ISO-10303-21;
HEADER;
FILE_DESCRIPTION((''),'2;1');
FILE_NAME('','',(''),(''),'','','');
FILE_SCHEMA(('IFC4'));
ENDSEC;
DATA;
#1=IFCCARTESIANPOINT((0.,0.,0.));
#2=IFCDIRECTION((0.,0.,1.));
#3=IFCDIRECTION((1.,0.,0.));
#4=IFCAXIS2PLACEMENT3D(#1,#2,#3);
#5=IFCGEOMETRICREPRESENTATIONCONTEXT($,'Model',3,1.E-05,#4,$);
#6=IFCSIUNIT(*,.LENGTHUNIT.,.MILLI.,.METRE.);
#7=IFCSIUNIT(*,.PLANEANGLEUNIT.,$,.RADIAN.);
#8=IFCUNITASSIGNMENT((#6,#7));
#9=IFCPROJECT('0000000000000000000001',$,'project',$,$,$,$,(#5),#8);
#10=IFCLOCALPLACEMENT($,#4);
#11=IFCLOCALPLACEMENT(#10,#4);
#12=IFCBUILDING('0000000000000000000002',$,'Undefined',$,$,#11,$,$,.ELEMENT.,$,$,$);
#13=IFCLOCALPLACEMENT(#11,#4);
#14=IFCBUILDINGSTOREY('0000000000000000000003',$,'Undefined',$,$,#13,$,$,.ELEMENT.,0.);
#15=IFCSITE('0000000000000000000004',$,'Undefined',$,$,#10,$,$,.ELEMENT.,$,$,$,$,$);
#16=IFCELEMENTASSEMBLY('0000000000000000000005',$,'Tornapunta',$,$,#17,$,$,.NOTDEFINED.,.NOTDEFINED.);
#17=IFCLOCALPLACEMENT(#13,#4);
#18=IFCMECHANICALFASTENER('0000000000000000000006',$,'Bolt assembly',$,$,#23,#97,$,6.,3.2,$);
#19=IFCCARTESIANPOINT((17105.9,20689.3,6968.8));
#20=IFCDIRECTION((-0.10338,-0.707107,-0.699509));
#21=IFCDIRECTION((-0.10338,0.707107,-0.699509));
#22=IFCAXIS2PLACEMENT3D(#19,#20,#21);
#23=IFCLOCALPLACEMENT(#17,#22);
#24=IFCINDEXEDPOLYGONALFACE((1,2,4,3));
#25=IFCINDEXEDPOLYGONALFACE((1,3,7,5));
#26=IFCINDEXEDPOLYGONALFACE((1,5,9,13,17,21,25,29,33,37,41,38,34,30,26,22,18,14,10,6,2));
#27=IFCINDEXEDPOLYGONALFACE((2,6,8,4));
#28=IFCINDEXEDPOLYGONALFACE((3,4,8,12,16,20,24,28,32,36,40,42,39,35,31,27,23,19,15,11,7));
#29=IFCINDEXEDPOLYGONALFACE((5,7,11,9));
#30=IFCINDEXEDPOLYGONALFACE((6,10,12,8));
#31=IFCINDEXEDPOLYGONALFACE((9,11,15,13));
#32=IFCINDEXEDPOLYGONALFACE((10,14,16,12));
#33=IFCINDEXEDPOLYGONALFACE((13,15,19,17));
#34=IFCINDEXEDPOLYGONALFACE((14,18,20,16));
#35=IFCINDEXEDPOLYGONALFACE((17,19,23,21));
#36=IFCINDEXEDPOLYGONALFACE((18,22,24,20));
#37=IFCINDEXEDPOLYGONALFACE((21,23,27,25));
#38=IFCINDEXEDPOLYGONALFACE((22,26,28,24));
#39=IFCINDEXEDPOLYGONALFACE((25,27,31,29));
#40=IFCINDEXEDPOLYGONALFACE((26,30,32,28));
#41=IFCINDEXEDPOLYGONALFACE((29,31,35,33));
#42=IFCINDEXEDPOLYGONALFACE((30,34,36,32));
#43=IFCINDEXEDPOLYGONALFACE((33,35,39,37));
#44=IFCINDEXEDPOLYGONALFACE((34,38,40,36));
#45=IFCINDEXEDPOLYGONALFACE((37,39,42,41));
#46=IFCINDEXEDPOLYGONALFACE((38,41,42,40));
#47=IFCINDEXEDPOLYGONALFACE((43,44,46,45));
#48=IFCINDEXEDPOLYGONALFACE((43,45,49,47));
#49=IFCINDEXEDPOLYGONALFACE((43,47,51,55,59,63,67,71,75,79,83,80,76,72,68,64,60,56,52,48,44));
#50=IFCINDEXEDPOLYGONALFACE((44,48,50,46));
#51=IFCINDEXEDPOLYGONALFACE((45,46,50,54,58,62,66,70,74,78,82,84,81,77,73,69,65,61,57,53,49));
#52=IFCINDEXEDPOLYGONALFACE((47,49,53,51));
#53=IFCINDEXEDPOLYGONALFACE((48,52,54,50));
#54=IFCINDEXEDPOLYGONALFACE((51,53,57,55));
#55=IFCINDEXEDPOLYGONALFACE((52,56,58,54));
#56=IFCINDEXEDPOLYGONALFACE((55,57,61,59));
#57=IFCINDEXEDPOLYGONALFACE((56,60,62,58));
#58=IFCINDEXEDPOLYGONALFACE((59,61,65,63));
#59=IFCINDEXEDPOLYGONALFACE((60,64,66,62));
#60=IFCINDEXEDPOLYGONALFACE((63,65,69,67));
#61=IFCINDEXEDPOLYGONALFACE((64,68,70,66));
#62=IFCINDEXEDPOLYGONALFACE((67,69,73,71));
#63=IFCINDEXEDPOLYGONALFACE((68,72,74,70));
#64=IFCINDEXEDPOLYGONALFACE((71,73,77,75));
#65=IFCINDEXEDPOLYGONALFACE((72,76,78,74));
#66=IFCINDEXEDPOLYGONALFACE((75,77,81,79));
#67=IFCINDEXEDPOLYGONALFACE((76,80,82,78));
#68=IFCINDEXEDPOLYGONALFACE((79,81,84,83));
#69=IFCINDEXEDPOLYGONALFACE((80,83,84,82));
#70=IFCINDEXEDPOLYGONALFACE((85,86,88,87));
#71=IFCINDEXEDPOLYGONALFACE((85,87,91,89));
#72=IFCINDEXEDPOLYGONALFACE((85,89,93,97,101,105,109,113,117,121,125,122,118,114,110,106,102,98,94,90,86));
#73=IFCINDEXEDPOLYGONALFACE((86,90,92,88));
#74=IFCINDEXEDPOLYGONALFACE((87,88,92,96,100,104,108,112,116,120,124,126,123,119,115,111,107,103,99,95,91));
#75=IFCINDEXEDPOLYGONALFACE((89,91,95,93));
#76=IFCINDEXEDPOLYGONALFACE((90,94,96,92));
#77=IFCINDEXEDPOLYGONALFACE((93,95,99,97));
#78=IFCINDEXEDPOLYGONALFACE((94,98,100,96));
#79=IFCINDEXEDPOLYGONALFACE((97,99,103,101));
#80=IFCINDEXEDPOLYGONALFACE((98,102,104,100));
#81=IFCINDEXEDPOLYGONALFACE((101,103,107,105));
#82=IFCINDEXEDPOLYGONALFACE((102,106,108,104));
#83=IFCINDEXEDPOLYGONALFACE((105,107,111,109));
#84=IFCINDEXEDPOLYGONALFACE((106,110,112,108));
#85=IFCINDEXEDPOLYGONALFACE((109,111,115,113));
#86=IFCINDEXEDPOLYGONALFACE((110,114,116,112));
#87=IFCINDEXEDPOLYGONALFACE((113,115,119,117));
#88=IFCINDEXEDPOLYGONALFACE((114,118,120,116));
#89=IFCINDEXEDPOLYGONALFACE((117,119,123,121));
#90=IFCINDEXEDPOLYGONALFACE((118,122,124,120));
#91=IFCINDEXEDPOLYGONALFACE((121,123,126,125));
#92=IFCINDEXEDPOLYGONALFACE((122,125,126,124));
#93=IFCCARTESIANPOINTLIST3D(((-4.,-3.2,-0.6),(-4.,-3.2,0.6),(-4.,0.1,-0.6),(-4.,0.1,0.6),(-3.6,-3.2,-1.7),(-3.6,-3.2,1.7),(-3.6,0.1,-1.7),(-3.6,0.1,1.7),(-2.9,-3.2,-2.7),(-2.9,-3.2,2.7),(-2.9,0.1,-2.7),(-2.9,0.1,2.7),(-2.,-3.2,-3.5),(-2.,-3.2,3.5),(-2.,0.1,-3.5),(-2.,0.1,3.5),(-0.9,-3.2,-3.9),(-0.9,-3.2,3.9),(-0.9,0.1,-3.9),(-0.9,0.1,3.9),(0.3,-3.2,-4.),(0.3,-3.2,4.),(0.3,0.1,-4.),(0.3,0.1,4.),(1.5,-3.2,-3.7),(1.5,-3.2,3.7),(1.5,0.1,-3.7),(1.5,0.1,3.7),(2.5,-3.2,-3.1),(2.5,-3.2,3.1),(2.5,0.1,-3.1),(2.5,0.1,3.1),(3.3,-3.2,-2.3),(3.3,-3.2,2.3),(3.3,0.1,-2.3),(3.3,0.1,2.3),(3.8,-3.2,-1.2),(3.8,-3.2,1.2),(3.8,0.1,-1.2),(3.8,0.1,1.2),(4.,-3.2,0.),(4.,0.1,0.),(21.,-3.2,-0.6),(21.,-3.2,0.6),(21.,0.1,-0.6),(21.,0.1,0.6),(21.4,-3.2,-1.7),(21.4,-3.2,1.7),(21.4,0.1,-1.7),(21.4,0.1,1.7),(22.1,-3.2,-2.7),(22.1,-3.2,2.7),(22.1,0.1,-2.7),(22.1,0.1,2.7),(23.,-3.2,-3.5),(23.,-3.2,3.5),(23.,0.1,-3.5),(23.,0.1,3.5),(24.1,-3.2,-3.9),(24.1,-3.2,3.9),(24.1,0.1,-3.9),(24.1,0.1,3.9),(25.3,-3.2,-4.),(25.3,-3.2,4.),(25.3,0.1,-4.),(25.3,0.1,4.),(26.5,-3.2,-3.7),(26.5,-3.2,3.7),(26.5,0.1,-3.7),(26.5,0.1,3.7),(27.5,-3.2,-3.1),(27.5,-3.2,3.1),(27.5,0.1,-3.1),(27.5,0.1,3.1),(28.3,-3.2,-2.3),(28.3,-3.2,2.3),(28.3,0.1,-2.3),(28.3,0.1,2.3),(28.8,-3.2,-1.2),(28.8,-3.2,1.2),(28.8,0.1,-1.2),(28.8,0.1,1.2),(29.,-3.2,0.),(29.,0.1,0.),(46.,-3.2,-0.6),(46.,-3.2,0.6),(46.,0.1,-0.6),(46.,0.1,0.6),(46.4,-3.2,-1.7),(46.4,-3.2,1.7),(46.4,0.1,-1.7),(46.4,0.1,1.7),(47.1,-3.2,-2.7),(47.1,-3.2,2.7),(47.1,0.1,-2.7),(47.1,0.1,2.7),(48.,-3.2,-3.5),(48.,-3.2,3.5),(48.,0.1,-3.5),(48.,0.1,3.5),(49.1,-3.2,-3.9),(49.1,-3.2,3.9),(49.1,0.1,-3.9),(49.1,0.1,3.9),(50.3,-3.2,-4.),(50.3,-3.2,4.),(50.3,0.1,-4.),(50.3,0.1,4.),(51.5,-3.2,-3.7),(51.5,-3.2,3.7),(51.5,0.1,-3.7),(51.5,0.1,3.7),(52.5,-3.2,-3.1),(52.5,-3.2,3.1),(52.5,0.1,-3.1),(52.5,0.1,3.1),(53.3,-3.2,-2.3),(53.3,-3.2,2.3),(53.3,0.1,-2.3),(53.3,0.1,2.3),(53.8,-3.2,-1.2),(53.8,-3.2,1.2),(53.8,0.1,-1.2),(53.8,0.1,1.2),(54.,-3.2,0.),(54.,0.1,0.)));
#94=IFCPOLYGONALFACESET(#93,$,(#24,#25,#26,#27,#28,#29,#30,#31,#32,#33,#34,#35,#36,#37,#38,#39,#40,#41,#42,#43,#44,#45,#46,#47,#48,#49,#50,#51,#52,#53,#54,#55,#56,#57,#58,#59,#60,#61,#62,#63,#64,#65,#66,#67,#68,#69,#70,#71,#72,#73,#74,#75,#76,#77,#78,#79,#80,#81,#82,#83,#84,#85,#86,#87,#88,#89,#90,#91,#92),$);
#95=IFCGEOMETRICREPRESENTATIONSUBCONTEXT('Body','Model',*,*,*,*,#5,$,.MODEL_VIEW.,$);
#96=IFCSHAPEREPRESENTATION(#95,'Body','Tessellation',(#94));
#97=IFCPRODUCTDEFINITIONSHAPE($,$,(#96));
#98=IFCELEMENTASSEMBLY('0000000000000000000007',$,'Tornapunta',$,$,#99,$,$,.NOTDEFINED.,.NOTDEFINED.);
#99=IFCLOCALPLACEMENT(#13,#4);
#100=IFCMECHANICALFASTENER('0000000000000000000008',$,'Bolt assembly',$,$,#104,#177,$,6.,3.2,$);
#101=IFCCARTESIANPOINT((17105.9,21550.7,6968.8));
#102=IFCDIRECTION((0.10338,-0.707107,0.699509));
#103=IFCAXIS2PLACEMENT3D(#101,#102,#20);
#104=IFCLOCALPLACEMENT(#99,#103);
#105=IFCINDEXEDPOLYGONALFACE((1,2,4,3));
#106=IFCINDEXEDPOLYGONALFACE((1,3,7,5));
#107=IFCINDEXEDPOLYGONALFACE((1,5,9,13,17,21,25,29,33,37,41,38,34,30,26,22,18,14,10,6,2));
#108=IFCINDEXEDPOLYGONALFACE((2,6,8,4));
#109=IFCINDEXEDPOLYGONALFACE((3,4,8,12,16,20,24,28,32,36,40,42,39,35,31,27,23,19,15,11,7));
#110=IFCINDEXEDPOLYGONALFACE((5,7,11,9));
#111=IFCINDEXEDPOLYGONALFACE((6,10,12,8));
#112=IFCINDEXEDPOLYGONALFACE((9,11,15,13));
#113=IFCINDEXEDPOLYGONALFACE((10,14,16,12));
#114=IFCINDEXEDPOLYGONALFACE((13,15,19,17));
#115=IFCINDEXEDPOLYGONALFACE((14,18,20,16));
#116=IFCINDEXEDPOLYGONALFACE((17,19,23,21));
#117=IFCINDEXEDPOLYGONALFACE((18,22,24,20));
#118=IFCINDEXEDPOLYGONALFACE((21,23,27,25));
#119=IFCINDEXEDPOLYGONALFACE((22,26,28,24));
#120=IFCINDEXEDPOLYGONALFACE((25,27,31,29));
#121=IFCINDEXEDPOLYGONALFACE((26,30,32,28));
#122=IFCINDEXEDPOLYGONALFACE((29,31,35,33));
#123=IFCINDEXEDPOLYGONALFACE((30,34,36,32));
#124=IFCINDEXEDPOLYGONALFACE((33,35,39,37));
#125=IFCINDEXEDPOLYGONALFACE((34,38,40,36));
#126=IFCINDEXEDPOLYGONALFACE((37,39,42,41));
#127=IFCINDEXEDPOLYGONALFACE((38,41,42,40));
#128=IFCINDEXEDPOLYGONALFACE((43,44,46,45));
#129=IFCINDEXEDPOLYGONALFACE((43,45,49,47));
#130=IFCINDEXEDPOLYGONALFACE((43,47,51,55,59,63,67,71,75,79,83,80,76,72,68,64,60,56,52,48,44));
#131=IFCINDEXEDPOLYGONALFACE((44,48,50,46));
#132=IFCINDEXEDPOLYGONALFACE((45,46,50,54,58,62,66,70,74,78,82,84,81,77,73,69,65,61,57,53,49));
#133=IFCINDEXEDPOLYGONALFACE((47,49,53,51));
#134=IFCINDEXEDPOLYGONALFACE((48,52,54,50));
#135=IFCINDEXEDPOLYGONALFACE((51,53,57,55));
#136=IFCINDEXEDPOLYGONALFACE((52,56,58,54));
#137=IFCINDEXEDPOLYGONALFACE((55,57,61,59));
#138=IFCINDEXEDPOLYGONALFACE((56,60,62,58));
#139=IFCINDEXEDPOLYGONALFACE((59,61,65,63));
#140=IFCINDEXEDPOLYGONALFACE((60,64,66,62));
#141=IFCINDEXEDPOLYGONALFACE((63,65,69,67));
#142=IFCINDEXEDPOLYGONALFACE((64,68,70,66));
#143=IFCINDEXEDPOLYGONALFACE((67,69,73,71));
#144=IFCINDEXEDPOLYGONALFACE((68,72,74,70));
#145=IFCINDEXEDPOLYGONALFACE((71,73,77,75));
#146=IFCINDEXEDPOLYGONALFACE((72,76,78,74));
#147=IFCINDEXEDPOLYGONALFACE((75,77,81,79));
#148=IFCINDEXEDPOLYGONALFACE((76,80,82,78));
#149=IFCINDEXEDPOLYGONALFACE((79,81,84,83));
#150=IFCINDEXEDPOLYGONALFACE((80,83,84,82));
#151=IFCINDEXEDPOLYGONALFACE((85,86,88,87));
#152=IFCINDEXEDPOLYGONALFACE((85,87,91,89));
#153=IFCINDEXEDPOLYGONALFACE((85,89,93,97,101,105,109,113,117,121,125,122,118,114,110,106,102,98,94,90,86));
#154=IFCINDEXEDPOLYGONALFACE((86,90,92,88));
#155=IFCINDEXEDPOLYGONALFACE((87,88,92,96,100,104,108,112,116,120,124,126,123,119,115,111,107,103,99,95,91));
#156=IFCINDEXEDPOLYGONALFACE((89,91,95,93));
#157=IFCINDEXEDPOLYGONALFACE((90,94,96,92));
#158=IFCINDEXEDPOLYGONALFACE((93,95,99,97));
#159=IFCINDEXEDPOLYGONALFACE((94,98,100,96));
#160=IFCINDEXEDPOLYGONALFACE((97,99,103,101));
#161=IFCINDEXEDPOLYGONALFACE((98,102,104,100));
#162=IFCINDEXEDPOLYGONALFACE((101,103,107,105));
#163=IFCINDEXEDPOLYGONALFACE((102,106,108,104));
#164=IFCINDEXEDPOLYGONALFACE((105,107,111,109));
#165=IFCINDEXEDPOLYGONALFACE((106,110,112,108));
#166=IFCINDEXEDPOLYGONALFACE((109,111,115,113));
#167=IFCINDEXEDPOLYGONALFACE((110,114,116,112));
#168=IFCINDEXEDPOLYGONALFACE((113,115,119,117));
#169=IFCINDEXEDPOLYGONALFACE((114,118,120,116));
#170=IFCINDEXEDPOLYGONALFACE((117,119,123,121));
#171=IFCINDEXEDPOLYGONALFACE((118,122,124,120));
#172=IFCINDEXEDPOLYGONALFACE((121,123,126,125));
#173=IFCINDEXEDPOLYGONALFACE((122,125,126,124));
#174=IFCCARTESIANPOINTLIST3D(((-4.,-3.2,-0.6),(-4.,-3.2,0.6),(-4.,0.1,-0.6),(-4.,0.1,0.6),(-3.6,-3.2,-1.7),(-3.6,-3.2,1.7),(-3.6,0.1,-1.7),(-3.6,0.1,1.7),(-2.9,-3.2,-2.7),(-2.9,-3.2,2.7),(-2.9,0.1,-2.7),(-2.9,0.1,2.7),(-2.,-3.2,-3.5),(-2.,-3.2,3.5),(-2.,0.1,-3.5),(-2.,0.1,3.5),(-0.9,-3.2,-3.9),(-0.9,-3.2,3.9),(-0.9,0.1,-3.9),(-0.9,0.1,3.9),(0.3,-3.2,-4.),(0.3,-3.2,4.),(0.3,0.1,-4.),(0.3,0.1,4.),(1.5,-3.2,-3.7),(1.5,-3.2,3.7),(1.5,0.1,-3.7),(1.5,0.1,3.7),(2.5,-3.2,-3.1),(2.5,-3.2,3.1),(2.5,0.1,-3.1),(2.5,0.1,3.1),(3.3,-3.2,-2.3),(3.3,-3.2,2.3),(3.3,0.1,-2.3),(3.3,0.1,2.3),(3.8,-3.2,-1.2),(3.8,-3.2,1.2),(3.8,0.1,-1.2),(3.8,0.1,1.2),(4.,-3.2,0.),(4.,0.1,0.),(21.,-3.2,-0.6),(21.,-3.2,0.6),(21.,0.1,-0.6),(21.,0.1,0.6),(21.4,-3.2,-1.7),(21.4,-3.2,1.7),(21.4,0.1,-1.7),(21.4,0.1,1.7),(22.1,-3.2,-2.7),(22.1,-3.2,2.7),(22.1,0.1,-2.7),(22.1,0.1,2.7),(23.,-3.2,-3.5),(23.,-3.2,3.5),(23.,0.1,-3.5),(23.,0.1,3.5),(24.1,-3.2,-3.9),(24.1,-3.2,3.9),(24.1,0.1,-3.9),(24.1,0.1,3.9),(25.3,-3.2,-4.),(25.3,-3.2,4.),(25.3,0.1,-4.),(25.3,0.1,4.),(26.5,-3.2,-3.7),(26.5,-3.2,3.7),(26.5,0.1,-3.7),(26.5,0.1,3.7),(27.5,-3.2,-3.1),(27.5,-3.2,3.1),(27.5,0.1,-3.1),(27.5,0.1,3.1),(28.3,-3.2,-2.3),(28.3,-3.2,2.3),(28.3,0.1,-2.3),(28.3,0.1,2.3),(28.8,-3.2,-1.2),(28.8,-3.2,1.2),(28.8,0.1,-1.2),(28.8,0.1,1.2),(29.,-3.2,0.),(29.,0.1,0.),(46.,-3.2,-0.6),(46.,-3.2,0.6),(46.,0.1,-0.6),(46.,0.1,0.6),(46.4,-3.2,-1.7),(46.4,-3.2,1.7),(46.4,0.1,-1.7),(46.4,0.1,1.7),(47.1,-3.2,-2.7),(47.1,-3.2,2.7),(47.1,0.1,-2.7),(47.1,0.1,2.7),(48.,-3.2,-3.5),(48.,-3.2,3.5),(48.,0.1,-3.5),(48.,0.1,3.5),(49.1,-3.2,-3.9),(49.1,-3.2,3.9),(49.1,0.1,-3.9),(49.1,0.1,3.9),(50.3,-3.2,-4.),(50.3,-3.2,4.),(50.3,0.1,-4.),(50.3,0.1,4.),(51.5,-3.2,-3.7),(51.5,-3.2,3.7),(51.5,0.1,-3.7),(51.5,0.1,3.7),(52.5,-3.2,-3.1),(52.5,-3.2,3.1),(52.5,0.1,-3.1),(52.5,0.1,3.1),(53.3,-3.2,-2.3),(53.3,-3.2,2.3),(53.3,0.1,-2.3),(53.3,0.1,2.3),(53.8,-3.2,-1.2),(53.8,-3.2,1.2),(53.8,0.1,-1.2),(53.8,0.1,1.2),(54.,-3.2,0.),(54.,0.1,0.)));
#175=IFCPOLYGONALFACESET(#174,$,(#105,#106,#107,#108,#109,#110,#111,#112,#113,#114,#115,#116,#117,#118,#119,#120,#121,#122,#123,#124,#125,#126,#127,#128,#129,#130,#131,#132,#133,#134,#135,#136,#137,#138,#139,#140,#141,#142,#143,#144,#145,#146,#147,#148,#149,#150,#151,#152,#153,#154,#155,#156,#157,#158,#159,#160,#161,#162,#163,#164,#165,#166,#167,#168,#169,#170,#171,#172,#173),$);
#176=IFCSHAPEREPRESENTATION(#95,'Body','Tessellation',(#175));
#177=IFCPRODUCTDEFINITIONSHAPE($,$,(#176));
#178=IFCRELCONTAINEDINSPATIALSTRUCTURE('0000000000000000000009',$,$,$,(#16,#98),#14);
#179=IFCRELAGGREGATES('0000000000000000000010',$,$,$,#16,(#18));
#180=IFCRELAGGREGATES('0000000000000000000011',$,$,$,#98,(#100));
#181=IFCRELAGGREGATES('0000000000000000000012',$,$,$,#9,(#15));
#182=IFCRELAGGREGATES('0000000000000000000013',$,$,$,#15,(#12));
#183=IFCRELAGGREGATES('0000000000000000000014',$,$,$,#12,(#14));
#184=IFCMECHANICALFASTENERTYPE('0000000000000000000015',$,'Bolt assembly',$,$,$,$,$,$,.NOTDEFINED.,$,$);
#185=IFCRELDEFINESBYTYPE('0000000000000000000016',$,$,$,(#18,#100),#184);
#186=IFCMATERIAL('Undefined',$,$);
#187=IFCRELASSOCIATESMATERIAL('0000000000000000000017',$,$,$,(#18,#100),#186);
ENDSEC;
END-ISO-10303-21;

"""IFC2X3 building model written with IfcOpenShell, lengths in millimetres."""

from ifc_helpers import new_model, si_unit, frame, origin_with_axes, origin_2d_with_axis, place, context, subcontext, project, spatial, circle, extrude, source, transform, mapped, material, type_object, element, aggregate, save


model = new_model("IFC2X3")

# Units and contexts
model_context = context("Model", 3, precision=1e-05, world=origin_with_axes())
body_context = subcontext(model_context, "Body", "Model", "MODEL_VIEW")
ifc_project = project(units=[si_unit("LENGTHUNIT", "METRE", prefix="MILLI"), si_unit("PLANEANGLEUNIT", "RADIAN")], contexts=[model_context])

# Site, building, storey
site_placement = place(None, origin_with_axes())
site = spatial("IfcSite", under=ifc_project, at=site_placement, Name="Undefined", CompositionType="ELEMENT")
building_placement = place(site_placement, origin_with_axes())
building = spatial("IfcBuilding", under=site, at=building_placement, Name="Undefined", CompositionType="ELEMENT")
storey_placement = place(building_placement, origin_with_axes())
storey = spatial("IfcBuildingStorey", under=building, at=storey_placement, Name="Undefined", CompositionType="ELEMENT", Elevation=0.0)

# Shared definitions
ifc_material_1 = material(Name="Undefined")
mechanical_fastener_type = type_object("IfcMechanicalFastenerType", Name="Bolt assembly")

# Element assemblies, mechanical fasteners
assembly_1_placement = place(storey_placement, origin_with_axes())
assembly_1 = element("IfcElementAssembly", 1, at=assembly_1_placement, inside=storey, Name="Tornapunta", AssemblyPlace="NOTDEFINED", PredefinedType="NOTDEFINED")
shared_shape_1 = source(origin_with_axes(), body_context, "Body", "SweptSolid", [
    extrude(circle(Radius=4.0, at=origin_2d_with_axis()), frame((0.0, -3.2, 0.0), z_axis=(0.0, 1.0, 0.0), x_axis=(1.0, 0.0, 0.0)), (0.0, 0.0, 1.0), 3.3),
])
mechanical_fastener_1_placement = place(assembly_1_placement, frame((17105.9, 20689.3, 6968.8), z_axis=(-0.10338, -0.707107, -0.699509), x_axis=(-0.10338, 0.707107, -0.699509)))
mechanical_fastener_1 = element("IfcMechanicalFastener", 2, at=mechanical_fastener_1_placement, type_object=mechanical_fastener_type, material=ifc_material_1, Name="Bolt assembly", NominalDiameter=6.0, NominalLength=3.2, context=body_context, shape_type="MappedRepresentation", body=[
    mapped(shared_shape_1, transform((0.0, 0.0, 0.0))),
    mapped(shared_shape_1, transform((25.0, 0.0, 0.0))),
    mapped(shared_shape_1, transform((50.0, 0.0, 0.0))),
])
aggregate(assembly_1, [mechanical_fastener_1])
assembly_2_placement = place(storey_placement, origin_with_axes())
assembly_2 = element("IfcElementAssembly", 3, at=assembly_2_placement, inside=storey, Name="Tornapunta", AssemblyPlace="NOTDEFINED", PredefinedType="NOTDEFINED")
mechanical_fastener_2_placement = place(assembly_2_placement, frame((17105.9, 21550.7, 6968.8), z_axis=(0.10338, -0.707107, 0.699509), x_axis=(-0.10338, -0.707107, -0.699509)))
mechanical_fastener_2 = element("IfcMechanicalFastener", 4, at=mechanical_fastener_2_placement, type_object=mechanical_fastener_type, material=ifc_material_1, Name="Bolt assembly", NominalDiameter=6.0, NominalLength=3.2, context=body_context, shape_type="MappedRepresentation", body=[
    mapped(shared_shape_1, transform((0.0, 0.0, 0.0))),
    mapped(shared_shape_1, transform((25.0, 0.0, 0.0))),
    mapped(shared_shape_1, transform((50.0, 0.0, 0.0))),
])
aggregate(assembly_2, [mechanical_fastener_2])

save(model, "model.ifc")
